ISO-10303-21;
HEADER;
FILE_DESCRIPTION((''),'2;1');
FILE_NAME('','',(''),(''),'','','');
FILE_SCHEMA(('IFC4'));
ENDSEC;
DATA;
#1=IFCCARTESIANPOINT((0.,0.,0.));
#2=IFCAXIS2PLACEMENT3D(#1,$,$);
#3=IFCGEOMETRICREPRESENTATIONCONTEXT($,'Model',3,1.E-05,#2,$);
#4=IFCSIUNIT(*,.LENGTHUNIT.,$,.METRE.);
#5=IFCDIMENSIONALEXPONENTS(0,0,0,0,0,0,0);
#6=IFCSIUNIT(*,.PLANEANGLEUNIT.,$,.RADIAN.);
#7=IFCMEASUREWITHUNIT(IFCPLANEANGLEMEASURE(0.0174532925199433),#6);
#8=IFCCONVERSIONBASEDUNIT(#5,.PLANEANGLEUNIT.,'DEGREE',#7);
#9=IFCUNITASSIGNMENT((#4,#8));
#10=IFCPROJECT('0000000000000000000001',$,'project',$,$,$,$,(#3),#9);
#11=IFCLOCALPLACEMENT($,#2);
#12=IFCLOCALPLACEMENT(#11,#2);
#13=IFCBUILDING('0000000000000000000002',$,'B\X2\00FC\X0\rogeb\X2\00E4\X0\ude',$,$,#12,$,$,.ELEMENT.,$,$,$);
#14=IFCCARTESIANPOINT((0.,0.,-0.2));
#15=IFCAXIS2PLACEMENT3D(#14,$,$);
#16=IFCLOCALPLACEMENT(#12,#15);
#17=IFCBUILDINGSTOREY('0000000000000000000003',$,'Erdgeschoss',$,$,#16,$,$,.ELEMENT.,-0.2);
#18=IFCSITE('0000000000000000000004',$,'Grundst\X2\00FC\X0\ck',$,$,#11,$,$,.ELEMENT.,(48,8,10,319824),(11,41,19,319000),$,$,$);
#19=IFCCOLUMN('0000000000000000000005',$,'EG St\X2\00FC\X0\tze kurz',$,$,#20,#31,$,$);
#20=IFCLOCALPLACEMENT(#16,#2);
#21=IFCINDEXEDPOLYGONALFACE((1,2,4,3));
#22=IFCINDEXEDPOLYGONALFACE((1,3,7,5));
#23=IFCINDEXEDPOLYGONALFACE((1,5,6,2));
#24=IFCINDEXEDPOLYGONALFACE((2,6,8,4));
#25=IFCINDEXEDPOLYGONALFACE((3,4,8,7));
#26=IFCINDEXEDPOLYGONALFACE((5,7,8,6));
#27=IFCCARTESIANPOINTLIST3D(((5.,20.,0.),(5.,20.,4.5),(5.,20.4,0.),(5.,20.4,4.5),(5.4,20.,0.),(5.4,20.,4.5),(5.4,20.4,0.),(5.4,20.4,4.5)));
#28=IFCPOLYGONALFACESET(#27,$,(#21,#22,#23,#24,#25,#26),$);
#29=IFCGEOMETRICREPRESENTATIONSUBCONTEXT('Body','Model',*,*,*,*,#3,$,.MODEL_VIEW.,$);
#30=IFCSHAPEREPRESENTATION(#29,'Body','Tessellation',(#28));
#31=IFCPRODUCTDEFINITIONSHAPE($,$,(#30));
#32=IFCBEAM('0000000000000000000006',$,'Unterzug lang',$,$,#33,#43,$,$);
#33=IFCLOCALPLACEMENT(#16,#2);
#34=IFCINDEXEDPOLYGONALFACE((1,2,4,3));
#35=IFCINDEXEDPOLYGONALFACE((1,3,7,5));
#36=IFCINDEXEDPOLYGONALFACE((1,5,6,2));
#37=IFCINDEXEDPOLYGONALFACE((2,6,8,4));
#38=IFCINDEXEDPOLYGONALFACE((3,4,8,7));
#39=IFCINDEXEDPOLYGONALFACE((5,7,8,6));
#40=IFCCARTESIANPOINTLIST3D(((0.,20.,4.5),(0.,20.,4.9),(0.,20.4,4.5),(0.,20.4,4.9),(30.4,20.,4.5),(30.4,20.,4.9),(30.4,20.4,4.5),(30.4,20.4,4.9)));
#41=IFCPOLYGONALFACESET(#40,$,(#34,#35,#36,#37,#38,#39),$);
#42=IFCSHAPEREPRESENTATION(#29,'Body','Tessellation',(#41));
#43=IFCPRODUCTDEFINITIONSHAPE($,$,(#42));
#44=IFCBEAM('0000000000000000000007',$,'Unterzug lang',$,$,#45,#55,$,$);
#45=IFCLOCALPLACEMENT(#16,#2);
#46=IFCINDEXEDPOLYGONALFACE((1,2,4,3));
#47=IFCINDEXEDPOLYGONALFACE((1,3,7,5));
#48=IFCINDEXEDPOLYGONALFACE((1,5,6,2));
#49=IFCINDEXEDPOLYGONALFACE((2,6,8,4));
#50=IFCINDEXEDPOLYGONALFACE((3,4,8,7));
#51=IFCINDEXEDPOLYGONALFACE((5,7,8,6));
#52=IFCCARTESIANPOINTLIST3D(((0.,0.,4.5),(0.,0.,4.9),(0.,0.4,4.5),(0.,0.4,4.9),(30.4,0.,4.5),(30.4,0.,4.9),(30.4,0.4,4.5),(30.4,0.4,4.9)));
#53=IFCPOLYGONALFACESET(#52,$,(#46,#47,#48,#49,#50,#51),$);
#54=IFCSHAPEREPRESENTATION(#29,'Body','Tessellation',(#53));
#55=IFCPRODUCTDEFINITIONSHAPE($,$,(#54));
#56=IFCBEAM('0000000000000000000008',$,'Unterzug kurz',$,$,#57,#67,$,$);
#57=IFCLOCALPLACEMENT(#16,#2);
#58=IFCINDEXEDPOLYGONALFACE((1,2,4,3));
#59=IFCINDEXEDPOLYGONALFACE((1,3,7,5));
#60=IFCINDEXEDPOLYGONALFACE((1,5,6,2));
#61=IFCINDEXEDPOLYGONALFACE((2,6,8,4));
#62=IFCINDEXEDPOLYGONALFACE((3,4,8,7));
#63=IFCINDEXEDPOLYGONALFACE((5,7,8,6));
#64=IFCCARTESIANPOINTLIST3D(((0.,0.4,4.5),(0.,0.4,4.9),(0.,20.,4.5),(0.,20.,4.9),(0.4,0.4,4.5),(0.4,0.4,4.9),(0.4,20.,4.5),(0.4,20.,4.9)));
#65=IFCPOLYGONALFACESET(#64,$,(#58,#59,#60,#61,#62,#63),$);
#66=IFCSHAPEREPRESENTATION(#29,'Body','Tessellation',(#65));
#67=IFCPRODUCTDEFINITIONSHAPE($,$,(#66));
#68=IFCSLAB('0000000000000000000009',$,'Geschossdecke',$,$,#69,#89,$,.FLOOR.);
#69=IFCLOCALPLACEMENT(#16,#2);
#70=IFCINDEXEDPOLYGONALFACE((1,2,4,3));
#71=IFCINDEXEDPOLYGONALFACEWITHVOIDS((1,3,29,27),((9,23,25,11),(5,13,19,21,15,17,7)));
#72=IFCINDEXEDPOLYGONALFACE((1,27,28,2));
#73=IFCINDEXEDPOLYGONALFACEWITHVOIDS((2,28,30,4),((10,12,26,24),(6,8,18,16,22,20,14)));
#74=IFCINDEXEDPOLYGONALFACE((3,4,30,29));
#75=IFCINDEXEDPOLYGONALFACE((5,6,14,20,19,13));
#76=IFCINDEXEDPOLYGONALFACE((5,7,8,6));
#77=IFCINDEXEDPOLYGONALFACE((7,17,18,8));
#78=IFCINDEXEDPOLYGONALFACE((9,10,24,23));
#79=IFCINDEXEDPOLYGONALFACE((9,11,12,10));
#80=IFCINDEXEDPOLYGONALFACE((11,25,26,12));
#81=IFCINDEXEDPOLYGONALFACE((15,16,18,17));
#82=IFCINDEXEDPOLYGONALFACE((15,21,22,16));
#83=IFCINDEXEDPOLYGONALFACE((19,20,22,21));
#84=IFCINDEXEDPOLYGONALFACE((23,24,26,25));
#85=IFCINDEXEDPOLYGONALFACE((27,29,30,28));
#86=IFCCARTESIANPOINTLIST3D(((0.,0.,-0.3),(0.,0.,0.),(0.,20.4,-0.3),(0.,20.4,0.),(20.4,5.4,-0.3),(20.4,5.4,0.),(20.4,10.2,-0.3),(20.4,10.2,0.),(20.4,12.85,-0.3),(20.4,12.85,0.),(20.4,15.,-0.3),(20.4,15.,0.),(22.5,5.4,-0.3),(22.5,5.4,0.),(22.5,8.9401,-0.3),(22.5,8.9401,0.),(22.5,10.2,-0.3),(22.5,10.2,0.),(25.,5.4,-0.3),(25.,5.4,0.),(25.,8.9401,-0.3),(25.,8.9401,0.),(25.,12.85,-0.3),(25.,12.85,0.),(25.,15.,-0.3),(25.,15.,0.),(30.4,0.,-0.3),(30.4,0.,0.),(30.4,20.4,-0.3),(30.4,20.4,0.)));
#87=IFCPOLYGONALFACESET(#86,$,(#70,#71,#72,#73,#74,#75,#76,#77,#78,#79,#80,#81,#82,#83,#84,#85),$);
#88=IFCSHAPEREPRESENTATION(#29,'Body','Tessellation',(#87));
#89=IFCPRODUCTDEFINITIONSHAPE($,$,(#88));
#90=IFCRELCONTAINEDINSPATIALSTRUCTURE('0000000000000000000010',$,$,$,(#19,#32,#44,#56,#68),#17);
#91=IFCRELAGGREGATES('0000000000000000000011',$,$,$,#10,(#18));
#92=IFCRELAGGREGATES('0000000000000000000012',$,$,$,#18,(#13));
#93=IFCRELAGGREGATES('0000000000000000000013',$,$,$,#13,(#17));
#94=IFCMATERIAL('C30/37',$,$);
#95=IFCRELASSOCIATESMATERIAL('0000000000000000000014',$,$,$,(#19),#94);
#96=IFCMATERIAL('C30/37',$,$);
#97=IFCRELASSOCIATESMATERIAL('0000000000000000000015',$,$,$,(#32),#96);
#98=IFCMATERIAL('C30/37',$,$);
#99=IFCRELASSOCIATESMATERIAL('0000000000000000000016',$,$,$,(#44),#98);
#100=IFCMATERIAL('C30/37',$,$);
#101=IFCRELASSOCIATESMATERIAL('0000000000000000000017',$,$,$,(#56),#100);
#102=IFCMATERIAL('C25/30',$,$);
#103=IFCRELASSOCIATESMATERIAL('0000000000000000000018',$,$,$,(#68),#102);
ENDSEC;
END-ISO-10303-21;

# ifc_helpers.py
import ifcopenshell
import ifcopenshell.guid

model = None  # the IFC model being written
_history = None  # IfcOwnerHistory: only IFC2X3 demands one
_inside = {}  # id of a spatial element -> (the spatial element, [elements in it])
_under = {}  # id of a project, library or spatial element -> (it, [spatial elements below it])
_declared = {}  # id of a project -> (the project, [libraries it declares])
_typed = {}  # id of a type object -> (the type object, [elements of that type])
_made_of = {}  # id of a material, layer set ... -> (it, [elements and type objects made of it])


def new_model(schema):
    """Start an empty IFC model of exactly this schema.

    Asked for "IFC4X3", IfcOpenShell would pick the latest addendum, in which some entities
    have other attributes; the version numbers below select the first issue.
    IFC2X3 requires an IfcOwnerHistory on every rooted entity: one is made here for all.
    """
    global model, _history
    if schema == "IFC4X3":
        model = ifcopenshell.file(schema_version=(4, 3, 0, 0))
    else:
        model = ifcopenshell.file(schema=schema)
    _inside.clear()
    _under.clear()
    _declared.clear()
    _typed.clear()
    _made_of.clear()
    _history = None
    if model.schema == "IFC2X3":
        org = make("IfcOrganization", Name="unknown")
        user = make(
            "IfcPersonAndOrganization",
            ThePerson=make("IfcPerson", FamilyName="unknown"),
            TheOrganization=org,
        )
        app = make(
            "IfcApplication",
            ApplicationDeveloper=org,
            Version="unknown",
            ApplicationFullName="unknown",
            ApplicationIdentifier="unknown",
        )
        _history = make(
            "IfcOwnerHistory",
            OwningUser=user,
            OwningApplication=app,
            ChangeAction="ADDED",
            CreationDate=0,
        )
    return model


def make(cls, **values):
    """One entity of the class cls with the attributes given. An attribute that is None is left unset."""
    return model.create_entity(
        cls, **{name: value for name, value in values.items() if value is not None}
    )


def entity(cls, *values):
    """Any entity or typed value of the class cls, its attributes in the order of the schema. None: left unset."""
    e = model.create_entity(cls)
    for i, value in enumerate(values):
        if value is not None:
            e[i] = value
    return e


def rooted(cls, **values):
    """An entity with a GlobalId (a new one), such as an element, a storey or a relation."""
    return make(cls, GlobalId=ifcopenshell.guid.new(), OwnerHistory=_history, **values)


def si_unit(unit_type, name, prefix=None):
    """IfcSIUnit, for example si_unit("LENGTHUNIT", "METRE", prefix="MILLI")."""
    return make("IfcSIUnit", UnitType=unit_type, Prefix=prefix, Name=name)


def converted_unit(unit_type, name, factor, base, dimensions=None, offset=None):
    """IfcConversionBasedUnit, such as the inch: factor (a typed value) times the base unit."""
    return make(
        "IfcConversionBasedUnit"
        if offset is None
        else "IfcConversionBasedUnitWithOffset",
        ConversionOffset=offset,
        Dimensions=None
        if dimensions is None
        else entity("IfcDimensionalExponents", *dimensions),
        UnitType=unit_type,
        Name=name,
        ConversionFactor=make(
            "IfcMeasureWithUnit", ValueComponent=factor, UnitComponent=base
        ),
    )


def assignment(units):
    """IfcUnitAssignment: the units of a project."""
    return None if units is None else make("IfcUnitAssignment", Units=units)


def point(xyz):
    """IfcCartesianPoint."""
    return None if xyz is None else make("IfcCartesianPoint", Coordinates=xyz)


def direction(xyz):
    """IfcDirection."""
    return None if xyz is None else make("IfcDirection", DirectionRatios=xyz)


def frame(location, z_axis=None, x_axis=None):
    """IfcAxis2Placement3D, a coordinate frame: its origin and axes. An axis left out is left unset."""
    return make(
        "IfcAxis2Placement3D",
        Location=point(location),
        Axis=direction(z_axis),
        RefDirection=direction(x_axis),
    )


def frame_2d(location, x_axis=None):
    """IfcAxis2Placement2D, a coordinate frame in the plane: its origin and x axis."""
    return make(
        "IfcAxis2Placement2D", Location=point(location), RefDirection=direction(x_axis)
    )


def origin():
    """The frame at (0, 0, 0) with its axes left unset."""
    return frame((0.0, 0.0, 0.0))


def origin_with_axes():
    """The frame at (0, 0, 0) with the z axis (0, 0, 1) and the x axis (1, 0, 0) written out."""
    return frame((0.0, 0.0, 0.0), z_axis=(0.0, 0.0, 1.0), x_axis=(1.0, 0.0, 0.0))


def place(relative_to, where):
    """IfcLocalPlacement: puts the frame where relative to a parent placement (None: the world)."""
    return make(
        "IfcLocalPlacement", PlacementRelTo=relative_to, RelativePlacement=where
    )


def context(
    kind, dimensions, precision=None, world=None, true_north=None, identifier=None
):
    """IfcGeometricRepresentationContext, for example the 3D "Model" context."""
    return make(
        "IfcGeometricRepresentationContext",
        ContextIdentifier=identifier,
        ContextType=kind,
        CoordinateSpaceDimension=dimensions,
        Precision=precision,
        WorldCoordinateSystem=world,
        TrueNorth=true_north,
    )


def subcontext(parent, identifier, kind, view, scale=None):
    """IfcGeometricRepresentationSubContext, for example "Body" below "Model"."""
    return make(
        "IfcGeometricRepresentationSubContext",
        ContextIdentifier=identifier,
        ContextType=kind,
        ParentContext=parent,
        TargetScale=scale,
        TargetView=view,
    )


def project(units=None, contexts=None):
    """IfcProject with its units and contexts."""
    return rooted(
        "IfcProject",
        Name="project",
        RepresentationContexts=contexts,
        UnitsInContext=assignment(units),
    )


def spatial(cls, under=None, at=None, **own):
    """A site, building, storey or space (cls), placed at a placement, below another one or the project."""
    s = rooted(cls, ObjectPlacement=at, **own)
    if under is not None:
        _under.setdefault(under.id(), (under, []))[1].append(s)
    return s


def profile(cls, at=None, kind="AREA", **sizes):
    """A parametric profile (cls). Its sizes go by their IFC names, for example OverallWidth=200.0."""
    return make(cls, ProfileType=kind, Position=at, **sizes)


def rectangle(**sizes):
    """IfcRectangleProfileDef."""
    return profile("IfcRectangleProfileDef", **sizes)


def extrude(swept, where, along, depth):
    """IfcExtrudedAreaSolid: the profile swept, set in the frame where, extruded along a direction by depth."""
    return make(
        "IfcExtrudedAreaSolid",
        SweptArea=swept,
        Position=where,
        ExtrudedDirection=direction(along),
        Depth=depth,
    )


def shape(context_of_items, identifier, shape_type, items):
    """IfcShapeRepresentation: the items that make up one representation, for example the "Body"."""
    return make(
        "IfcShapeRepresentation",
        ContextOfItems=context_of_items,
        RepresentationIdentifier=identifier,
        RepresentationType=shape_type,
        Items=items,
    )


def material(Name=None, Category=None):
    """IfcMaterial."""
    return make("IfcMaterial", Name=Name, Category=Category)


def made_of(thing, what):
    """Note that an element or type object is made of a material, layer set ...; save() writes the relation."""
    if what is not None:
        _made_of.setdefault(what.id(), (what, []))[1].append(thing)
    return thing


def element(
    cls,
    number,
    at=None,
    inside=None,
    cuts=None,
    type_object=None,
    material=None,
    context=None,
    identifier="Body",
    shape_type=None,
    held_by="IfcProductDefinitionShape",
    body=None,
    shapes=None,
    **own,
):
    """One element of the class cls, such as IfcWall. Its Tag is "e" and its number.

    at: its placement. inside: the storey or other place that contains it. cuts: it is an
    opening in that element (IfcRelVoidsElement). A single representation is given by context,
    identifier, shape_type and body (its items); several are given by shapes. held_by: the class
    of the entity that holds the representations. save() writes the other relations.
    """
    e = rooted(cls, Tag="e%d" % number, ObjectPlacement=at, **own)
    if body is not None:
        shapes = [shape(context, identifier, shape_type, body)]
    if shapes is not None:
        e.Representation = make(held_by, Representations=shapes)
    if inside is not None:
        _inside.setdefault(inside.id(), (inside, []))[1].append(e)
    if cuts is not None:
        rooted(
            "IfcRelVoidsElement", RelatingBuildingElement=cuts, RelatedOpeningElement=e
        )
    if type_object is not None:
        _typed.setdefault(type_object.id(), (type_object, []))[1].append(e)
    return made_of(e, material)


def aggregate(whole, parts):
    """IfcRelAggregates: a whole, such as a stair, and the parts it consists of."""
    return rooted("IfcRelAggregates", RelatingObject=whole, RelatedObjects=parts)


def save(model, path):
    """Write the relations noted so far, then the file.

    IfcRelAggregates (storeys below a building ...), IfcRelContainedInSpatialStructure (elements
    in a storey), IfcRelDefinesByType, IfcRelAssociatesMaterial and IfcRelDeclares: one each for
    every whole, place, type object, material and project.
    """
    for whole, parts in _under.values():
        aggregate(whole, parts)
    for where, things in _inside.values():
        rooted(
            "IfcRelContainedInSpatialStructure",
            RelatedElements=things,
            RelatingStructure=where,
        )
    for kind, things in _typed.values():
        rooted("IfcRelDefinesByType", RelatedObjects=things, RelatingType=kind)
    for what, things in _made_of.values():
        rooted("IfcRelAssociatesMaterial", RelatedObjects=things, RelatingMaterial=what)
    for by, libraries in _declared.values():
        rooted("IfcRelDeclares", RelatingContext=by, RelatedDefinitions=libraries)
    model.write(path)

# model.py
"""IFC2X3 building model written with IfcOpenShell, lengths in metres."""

from ifc_helpers import new_model, entity, si_unit, converted_unit, frame, frame_2d, origin, origin_with_axes, place, context, subcontext, project, spatial, rectangle, extrude, material, element, save


model = new_model("IFC2X3")

# Units and contexts
model_context = context("Model", 3, precision=1e-05, world=origin())
body_context = subcontext(model_context, "Body", "Model", "MODEL_VIEW")
ifc_project = project(units=[si_unit("LENGTHUNIT", "METRE"), converted_unit("PLANEANGLEUNIT", "DEGREE", entity("IfcPlaneAngleMeasure", 0.0174532925199433), si_unit("PLANEANGLEUNIT", "RADIAN"), dimensions=[0, 0, 0, 0, 0, 0, 0])], contexts=[model_context])

# Site, building, storey
site_placement = place(None, origin())
site = spatial("IfcSite", under=ifc_project, at=site_placement, Name="Grundstück", CompositionType="ELEMENT", RefLatitude=(48, 8, 10, 319824), RefLongitude=(11, 41, 19, 319000))
building_placement = place(site_placement, origin())
building = spatial("IfcBuilding", under=site, at=building_placement, Name="Bürogebäude", CompositionType="ELEMENT")
storey_placement = place(building_placement, frame((0.0, 0.0, -0.2)))
storey = spatial("IfcBuildingStorey", under=building, at=storey_placement, Name="Erdgeschoss", CompositionType="ELEMENT", Elevation=-0.2)

# Column
ifc_material_1 = material(Name="C30/37")
column_1_placement = place(storey_placement, frame((5.0, 20.0, 0.0)))
element("IfcColumn", 1, at=column_1_placement, inside=storey, material=ifc_material_1, Name="EG Stütze kurz", context=body_context, shape_type="SweptSolid", body=[
    extrude(rectangle(XDim=0.4, YDim=0.4, at=frame_2d((0.2, 0.2), x_axis=(1.0, 0.0))), origin_with_axes(), (0.0, 0.0, 1.0), 4.5),
])

# Beams
ifc_material_2 = material(Name="C30/37")
beam_1_placement = place(storey_placement, frame((0.0, 20.0, 4.5)))
element("IfcBeam", 2, at=beam_1_placement, inside=storey, material=ifc_material_2, Name="Unterzug lang", context=body_context, shape_type="SweptSolid", body=[
    extrude(rectangle(XDim=0.4, YDim=0.4, at=frame_2d((0.2, 0.2), x_axis=(1.0, 0.0))), frame((0.0, 0.0, 0.0), z_axis=(1.0, 0.0, 0.0), x_axis=(0.0, 1.0, 0.0)), (0.0, 0.0, 1.0), 30.4),
])
ifc_material_3 = material(Name="C30/37")
beam_2_placement = place(storey_placement, frame((0.0, 0.0, 4.5), z_axis=(0.0, 0.0, 1.0), x_axis=(1.0, 0.0, 0.0)))
element("IfcBeam", 3, at=beam_2_placement, inside=storey, material=ifc_material_3, Name="Unterzug lang", context=body_context, shape_type="SweptSolid", body=[
    extrude(rectangle(XDim=0.4, YDim=0.4, at=frame_2d((0.2, 0.2), x_axis=(1.0, 0.0))), frame((0.0, 0.0, 0.0), z_axis=(1.0, 0.0, 0.0), x_axis=(0.0, 1.0, 0.0)), (0.0, 0.0, 1.0), 30.4),
])
ifc_material_4 = material(Name="C30/37")
beam_3_placement = place(storey_placement, frame((0.0, 20.0, 4.5), z_axis=(0.0, 0.0, 1.0), x_axis=(0.0, -1.0, 0.0)))
element("IfcBeam", 4, at=beam_3_placement, inside=storey, material=ifc_material_4, Name="Unterzug kurz", context=body_context, shape_type="SweptSolid", body=[
    extrude(rectangle(XDim=0.4, YDim=0.4, at=frame_2d((0.2, 0.2), x_axis=(1.0, 0.0))), frame((0.0, 0.0, 0.0), z_axis=(1.0, 0.0, 0.0), x_axis=(0.0, 1.0, 0.0)), (0.0, 0.0, 1.0), 19.6),
])

# Slab, openings
ifc_material_5 = material(Name="C25/30")
slab_placement = place(storey_placement, frame((0.0, 0.0, -0.3)))
slab = element("IfcSlab", 5, at=slab_placement, inside=storey, material=ifc_material_5, Name="Geschossdecke", PredefinedType="FLOOR", context=body_context, shape_type="SweptSolid", body=[
    extrude(rectangle(XDim=30.4, YDim=20.4, at=frame_2d((15.2, 10.2), x_axis=(1.0, 0.0))), frame((0.0, 0.0, 0.0), z_axis=(0.0, 0.0, 1.0), x_axis=(1.0, 0.0, 0.0)), (0.0, 0.0, 1.0), 0.3),
])
opening_1_placement = place(slab_placement, frame((20.4, 5.4, 0.0)))
element("IfcOpeningElement", 6, at=opening_1_placement, cuts=slab, ObjectType="Opening", context=body_context, shape_type="SweptSolid", body=[
    extrude(rectangle(XDim=4.8, YDim=2.1, at=frame_2d((0.0, 0.0), x_axis=(0.0, -1.0))), frame((1.05, 2.4, 0.0), z_axis=(0.0, 0.0, 1.0), x_axis=(1.0, 0.0, 0.0)), (0.0, 0.0, 1.0), 0.3),
])
opening_2_placement = place(slab_placement, frame((22.5, 5.4, 0.0)))
element("IfcOpeningElement", 7, at=opening_2_placement, cuts=slab, ObjectType="Opening", context=body_context, shape_type="SweptSolid", body=[
    extrude(rectangle(XDim=3.5401, YDim=2.5, at=frame_2d((0.0, 0.0), x_axis=(0.0, -1.0))), frame((1.25, 1.77, 0.0), z_axis=(0.0, 0.0, 1.0), x_axis=(1.0, 0.0, 0.0)), (0.0, 0.0, 1.0), 0.3),
])
opening_3_placement = place(slab_placement, frame((20.4, 12.85, 0.0)))
element("IfcOpeningElement", 8, at=opening_3_placement, cuts=slab, ObjectType="Opening", context=body_context, shape_type="SweptSolid", body=[
    extrude(rectangle(XDim=2.15, YDim=4.6, at=frame_2d((0.0, 0.0), x_axis=(0.0, -1.0))), frame((2.3, 1.075, 0.0), z_axis=(0.0, 0.0, 1.0), x_axis=(1.0, 0.0, 0.0)), (0.0, 0.0, 1.0), 0.3),
])

save(model, "model.ifc")
